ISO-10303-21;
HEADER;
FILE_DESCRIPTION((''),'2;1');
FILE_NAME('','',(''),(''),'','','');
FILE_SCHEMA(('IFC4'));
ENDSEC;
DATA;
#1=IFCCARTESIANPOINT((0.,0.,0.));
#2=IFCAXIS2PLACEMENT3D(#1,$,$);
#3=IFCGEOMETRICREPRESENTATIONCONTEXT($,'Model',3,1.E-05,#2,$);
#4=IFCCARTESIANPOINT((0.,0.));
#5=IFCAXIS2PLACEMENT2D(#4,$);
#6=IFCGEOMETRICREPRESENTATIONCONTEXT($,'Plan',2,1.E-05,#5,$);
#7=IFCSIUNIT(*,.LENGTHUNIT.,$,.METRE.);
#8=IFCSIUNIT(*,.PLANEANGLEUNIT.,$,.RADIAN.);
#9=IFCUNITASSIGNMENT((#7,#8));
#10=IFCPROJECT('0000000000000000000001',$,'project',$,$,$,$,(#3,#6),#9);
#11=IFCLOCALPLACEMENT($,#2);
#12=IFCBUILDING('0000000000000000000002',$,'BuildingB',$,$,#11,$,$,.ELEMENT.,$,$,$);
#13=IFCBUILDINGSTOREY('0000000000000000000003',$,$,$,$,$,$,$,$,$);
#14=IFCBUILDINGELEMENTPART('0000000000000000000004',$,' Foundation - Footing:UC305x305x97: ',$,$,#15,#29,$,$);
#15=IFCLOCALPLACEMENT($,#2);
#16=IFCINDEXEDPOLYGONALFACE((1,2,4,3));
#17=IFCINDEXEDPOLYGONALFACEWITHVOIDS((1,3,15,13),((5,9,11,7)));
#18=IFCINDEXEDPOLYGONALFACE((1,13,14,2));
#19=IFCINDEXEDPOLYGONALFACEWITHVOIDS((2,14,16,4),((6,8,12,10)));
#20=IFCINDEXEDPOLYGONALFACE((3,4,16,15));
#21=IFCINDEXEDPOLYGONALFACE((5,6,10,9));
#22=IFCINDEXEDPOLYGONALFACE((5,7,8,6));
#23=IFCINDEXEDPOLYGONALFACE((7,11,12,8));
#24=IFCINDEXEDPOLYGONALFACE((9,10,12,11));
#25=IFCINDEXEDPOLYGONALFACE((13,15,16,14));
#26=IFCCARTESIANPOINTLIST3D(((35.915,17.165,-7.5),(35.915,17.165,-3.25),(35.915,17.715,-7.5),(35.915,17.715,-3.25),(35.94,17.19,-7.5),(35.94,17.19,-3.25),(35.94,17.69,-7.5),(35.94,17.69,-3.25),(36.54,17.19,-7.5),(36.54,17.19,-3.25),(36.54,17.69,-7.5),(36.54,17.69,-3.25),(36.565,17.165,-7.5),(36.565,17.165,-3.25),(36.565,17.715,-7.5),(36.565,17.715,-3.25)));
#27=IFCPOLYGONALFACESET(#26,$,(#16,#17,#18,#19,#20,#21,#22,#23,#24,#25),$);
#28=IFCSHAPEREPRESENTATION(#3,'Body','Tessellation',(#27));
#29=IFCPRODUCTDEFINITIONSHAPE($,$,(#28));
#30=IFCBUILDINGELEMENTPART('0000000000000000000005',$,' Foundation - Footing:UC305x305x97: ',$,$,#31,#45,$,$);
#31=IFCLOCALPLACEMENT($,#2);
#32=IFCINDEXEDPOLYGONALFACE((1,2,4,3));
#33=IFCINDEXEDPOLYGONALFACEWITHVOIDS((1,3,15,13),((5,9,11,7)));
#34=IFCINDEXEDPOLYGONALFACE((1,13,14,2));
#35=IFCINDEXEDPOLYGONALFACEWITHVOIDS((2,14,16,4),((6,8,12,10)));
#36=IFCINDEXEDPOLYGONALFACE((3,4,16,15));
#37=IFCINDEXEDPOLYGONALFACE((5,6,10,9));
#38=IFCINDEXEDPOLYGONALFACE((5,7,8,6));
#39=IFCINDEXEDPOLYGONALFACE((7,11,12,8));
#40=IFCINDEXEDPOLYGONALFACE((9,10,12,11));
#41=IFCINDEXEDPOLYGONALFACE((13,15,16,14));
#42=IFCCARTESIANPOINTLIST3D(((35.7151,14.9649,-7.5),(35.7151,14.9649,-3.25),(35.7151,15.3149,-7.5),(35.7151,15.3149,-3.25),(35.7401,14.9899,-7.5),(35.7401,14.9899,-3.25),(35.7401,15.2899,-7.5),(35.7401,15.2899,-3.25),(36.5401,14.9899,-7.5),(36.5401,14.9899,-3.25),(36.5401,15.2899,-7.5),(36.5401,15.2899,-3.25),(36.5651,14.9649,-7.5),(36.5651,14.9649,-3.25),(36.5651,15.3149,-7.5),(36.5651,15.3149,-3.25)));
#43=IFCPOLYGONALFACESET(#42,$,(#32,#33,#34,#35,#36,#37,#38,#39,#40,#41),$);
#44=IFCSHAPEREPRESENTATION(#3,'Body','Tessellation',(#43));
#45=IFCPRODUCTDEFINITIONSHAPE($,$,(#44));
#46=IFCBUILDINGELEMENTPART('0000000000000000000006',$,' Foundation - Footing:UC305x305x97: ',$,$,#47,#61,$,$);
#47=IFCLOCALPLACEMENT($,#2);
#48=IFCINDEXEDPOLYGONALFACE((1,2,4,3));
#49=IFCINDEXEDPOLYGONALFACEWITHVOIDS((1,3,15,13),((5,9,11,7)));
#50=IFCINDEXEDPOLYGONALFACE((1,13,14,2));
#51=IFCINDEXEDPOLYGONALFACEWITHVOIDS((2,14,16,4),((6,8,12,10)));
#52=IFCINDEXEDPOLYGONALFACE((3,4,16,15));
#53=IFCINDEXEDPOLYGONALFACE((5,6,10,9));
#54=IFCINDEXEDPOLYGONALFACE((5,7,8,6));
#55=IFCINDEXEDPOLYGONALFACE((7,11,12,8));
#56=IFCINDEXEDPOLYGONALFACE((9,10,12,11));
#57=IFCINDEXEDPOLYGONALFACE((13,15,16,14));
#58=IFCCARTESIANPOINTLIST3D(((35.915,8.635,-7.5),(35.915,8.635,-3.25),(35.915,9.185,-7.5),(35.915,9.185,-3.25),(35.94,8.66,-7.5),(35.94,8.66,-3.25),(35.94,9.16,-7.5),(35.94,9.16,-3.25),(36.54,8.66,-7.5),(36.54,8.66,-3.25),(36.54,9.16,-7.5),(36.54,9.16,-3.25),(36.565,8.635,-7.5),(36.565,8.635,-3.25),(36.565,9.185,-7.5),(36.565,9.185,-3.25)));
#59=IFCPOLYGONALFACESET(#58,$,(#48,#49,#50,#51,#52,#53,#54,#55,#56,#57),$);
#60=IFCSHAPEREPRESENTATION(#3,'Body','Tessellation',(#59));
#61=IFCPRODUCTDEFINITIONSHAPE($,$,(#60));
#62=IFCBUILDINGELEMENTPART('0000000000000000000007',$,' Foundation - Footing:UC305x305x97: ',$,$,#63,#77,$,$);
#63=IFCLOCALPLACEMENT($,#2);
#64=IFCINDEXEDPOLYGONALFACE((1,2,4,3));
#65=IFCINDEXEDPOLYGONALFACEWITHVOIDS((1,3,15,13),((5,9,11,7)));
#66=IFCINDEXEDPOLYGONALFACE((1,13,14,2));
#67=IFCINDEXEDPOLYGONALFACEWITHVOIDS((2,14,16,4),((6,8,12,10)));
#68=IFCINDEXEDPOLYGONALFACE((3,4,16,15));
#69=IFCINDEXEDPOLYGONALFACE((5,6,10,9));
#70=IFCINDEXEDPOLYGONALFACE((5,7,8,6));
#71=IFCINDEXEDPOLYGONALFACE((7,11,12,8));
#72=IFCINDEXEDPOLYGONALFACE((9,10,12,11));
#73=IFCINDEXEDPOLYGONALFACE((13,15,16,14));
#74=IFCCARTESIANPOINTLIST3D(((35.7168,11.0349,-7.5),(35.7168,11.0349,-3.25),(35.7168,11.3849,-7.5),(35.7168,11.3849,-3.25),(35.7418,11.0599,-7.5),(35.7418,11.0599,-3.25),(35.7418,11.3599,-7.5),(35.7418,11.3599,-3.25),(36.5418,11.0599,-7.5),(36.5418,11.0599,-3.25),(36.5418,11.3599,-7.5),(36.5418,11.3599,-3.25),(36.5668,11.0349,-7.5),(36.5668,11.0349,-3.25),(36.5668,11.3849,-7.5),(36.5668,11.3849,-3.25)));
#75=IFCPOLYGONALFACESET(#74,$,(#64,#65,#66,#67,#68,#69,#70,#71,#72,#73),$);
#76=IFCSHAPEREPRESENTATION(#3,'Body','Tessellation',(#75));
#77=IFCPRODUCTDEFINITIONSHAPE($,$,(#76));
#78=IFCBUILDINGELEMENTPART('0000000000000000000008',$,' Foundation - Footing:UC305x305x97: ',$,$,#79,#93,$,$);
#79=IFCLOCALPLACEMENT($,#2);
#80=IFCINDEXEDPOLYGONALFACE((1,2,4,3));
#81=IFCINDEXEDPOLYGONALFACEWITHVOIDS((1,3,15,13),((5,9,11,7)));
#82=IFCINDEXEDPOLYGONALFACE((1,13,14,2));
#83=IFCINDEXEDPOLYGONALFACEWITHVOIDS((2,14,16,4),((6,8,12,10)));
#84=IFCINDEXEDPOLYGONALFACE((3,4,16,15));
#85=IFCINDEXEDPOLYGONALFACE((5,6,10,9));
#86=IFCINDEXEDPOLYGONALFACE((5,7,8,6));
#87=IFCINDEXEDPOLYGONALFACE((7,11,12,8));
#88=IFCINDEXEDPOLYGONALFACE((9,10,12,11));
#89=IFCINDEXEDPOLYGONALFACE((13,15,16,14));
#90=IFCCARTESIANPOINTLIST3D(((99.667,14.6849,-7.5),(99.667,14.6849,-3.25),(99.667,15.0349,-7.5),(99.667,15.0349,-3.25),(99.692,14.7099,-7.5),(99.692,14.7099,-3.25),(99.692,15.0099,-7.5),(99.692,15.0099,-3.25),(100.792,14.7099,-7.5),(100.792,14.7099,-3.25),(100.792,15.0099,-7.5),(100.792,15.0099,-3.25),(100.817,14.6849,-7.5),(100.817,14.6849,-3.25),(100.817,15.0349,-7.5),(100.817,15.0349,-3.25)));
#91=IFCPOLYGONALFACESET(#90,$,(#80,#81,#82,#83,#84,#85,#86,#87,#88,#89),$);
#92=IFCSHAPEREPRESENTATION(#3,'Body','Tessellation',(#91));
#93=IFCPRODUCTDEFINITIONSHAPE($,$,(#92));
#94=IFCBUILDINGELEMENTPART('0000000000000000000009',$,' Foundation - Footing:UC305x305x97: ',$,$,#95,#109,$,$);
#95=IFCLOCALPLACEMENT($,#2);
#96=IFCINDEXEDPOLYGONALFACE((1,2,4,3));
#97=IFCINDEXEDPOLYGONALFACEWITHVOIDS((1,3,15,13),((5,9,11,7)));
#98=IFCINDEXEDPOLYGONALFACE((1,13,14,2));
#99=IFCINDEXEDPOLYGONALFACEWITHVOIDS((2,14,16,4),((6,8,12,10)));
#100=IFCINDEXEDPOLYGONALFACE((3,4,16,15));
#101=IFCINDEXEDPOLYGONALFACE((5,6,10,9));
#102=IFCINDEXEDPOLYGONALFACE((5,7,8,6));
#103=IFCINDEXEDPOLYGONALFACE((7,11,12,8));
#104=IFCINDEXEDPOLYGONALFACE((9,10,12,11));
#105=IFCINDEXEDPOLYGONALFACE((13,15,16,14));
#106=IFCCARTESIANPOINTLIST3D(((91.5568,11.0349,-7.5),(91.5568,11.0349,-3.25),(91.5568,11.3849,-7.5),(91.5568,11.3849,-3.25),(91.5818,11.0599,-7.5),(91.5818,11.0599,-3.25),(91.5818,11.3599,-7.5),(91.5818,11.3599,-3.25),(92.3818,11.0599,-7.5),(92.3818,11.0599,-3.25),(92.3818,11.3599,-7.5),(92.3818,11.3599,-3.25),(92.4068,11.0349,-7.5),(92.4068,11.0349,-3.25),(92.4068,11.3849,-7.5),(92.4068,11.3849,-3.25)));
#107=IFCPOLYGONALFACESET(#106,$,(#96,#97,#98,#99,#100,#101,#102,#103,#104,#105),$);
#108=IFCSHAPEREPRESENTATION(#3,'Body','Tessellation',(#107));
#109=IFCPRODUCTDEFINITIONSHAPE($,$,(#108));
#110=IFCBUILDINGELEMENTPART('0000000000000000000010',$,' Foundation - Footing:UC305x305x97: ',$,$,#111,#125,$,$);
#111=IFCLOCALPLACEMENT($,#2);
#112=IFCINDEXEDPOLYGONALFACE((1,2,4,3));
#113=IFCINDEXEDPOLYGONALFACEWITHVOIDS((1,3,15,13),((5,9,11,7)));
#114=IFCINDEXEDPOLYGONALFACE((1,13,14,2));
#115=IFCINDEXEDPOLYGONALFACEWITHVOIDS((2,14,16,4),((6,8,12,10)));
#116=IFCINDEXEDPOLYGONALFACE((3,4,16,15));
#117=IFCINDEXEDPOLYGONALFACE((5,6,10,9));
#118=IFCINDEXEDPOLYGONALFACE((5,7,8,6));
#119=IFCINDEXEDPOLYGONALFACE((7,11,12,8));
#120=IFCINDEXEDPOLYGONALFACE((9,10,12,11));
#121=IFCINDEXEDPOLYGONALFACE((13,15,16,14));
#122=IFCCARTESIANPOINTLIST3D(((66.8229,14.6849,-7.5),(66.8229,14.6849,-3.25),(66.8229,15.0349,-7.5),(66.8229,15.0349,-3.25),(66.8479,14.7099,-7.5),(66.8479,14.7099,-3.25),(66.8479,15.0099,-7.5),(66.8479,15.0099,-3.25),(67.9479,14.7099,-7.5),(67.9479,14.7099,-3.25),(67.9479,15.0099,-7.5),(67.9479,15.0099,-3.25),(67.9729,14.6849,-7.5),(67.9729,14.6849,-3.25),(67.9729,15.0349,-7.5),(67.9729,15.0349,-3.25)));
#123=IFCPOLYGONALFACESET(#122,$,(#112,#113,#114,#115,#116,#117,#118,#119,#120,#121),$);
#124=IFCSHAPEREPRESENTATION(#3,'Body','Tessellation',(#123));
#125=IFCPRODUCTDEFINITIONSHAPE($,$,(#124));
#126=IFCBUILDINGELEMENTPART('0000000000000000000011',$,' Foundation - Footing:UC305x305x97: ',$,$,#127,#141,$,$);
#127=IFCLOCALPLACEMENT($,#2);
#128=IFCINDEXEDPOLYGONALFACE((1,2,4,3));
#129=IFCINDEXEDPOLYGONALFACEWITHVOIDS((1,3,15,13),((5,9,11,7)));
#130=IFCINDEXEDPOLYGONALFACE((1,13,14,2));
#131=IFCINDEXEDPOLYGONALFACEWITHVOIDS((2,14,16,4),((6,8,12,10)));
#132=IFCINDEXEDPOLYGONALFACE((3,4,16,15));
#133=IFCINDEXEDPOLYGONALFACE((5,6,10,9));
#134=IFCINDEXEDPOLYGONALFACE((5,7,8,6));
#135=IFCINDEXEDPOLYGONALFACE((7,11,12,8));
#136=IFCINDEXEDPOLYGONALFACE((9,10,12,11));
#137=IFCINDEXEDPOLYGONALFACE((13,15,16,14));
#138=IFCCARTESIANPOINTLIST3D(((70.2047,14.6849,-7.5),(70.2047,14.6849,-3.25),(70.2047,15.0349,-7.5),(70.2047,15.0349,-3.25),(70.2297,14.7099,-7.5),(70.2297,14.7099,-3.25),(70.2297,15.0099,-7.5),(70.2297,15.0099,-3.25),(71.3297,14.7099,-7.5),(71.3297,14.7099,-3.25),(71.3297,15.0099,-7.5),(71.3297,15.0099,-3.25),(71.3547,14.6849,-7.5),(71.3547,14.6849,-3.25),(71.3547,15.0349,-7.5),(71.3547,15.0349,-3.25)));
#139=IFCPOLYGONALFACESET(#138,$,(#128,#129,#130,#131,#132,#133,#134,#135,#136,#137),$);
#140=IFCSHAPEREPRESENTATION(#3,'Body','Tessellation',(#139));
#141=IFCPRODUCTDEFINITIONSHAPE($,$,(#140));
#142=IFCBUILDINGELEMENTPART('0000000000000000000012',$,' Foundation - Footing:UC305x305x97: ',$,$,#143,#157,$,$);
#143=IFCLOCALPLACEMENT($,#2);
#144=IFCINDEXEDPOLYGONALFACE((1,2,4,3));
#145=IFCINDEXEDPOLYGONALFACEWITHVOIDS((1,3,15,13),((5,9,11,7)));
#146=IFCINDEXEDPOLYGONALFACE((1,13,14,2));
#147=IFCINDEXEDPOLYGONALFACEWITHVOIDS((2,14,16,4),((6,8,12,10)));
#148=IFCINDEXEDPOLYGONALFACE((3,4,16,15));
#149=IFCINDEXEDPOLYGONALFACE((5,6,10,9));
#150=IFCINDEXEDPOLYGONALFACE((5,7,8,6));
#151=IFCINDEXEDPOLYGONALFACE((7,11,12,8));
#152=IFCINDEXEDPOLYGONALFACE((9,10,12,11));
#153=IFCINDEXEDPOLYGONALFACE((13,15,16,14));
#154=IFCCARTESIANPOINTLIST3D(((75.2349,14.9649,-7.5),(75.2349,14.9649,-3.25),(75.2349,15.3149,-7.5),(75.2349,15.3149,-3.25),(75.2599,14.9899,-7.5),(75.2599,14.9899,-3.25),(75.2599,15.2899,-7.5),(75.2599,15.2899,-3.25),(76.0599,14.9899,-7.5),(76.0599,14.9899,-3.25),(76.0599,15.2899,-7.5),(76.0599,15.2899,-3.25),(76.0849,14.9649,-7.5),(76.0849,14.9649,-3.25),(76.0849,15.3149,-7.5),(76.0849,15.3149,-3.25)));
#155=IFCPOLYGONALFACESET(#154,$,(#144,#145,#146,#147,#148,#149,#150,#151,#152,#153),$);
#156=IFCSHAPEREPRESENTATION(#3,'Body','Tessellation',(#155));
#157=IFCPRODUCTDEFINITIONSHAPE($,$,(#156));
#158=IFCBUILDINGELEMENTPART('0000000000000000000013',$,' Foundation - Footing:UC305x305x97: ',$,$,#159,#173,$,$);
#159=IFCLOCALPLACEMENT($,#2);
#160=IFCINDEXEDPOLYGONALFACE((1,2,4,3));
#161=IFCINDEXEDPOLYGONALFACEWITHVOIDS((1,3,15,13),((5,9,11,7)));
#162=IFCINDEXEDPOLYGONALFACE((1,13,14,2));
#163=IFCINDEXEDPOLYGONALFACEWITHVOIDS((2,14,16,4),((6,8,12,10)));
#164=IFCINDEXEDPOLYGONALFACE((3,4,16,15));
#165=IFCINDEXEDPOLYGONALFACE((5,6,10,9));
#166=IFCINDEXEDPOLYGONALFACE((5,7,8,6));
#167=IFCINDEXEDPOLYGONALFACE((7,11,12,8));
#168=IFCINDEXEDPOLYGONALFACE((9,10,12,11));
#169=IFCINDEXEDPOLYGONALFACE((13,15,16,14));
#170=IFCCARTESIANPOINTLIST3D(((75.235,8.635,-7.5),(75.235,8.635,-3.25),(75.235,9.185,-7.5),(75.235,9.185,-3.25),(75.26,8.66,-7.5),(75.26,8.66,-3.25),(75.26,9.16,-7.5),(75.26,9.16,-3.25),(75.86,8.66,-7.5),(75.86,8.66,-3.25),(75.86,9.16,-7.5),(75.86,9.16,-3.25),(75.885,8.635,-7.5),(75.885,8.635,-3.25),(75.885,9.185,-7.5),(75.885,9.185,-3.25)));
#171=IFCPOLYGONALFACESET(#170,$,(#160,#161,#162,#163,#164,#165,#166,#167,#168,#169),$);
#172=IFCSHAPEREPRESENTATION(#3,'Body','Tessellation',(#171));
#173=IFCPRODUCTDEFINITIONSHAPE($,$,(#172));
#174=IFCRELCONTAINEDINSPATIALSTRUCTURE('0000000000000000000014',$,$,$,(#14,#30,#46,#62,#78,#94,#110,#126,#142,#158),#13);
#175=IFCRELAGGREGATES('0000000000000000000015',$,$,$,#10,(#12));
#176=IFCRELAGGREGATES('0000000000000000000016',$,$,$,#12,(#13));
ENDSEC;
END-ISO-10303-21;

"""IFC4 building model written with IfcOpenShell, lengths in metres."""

from ifc_helpers import new_model, si_unit, origin, origin_2d, place, context, project, spatial, polyline, outline, extrude, element, save


model = new_model("IFC4")

# Units and contexts
model_context = context("Model", 3, precision=1e-05, world=origin())
plan_context = context("Plan", 2, precision=1e-05, world=origin_2d())
ifc_project = project(units=[si_unit("LENGTHUNIT", "METRE"), si_unit("PLANEANGLEUNIT", "RADIAN")], contexts=[model_context, plan_context])

# Building, storey
building_placement = place(None, origin())
building = spatial("IfcBuilding", under=ifc_project, at=building_placement, Name="BuildingB", CompositionType="ELEMENT")
storey = spatial("IfcBuildingStorey", under=building)

# Building element parts, openings
building_element_part_1 = element("IfcBuildingElementPart", 1, inside=storey, Name=" Foundation - Footing:UC305x305x97: ", context=model_context, shape_type="SweptSolid", body=[
    extrude(outline(polyline([(36.565, 17.715, -7.5), (35.915, 17.715, -7.5), (35.915, 17.165, -7.5), (36.565, 17.165, -7.5), (36.565, 17.715, -7.5)])), None, (0.0, 0.0, 1.0), 4.25),
])
element("IfcOpeningElement", 2, inside=storey, cuts=building_element_part_1, context=model_context, shape_type="SweptSolid", body=[
    extrude(outline(polyline([(36.54, 17.69, -7.5), (35.94, 17.69, -7.5), (35.94, 17.19, -7.5), (36.54, 17.19, -7.5), (36.54, 17.69, -7.5)])), None, (0.0, 0.0, 1.0), 4.25),
])
building_element_part_2 = element("IfcBuildingElementPart", 3, inside=storey, Name=" Foundation - Footing:UC305x305x97: ", context=model_context, shape_type="SweptSolid", body=[
    extrude(outline(polyline([(36.5651, 15.3149, -7.5), (35.7151, 15.3149, -7.5), (35.7151, 14.9649, -7.5), (36.5651, 14.9649, -7.5), (36.5651, 15.3149, -7.5)])), None, (0.0, 0.0, 1.0), 4.25),
])
element("IfcOpeningElement", 4, inside=storey, cuts=building_element_part_2, context=model_context, shape_type="SweptSolid", body=[
    extrude(outline(polyline([(36.5401, 15.2899, -7.5), (35.7401, 15.2899, -7.5), (35.7401, 14.9899, -7.5), (36.5401, 14.9899, -7.5), (36.5401, 15.2899, -7.5)])), None, (0.0, 0.0, 1.0), 4.25),
])
building_element_part_3 = element("IfcBuildingElementPart", 5, inside=storey, Name=" Foundation - Footing:UC305x305x97: ", context=model_context, shape_type="SweptSolid", body=[
    extrude(outline(polyline([(36.565, 8.635, -7.5), (35.915, 8.635, -7.5), (35.915, 9.185, -7.5), (36.565, 9.185, -7.5), (36.565, 8.635, -7.5)])), None, (0.0, 0.0, 1.0), 4.25),
])
element("IfcOpeningElement", 6, inside=storey, cuts=building_element_part_3, context=model_context, shape_type="SweptSolid", body=[
    extrude(outline(polyline([(36.54, 8.66, -7.5), (35.94, 8.66, -7.5), (35.94, 9.16, -7.5), (36.54, 9.16, -7.5), (36.54, 8.66, -7.5)])), None, (0.0, 0.0, 1.0), 4.25),
])
building_element_part_4 = element("IfcBuildingElementPart", 7, inside=storey, Name=" Foundation - Footing:UC305x305x97: ", context=model_context, shape_type="SweptSolid", body=[
    extrude(outline(polyline([(36.5668, 11.0349, -7.5), (35.7168, 11.0349, -7.5), (35.7168, 11.3849, -7.5), (36.5668, 11.3849, -7.5), (36.5668, 11.0349, -7.5)])), None, (0.0, 0.0, 1.0), 4.25),
])
element("IfcOpeningElement", 8, inside=storey, cuts=building_element_part_4, context=model_context, shape_type="SweptSolid", body=[
    extrude(outline(polyline([(36.5418, 11.0599, -7.5), (35.7418, 11.0599, -7.5), (35.7418, 11.3599, -7.5), (36.5418, 11.3599, -7.5), (36.5418, 11.0599, -7.5)])), None, (0.0, 0.0, 1.0), 4.25),
])
building_element_part_5 = element("IfcBuildingElementPart", 9, inside=storey, Name=" Foundation - Footing:UC305x305x97: ", context=model_context, shape_type="SweptSolid", body=[
    extrude(outline(polyline([(100.817, 14.6849, -7.5), (100.817, 15.0349, -7.5), (99.667, 15.0349, -7.5), (99.667, 14.6849, -7.5), (100.817, 14.6849, -7.5)])), None, (0.0, 0.0, 1.0), 4.25),
])
element("IfcOpeningElement", 10, inside=storey, cuts=building_element_part_5, context=model_context, shape_type="SweptSolid", body=[
    extrude(outline(polyline([(100.792, 14.7099, -7.5), (100.792, 15.0099, -7.5), (99.692, 15.0099, -7.5), (99.692, 14.7099, -7.5), (100.792, 14.7099, -7.5)])), None, (0.0, 0.0, 1.0), 4.25),
])
building_element_part_6 = element("IfcBuildingElementPart", 11, inside=storey, Name=" Foundation - Footing:UC305x305x97: ", context=model_context, shape_type="SweptSolid", body=[
    extrude(outline(polyline([(92.4068, 11.0349, -7.5), (91.5568, 11.0349, -7.5), (91.5568, 11.3849, -7.5), (92.4068, 11.3849, -7.5), (92.4068, 11.0349, -7.5)])), None, (0.0, 0.0, 1.0), 4.25),
])
element("IfcOpeningElement", 12, inside=storey, cuts=building_element_part_6, context=model_context, shape_type="SweptSolid", body=[
    extrude(outline(polyline([(92.3818, 11.0599, -7.5), (91.5818, 11.0599, -7.5), (91.5818, 11.3599, -7.5), (92.3818, 11.3599, -7.5), (92.3818, 11.0599, -7.5)])), None, (0.0, 0.0, 1.0), 4.25),
])
building_element_part_7 = element("IfcBuildingElementPart", 13, inside=storey, Name=" Foundation - Footing:UC305x305x97: ", context=model_context, shape_type="SweptSolid", body=[
    extrude(outline(polyline([(66.8229, 14.6849, -7.5), (66.8229, 15.0349, -7.5), (67.9729, 15.0349, -7.5), (67.9729, 14.6849, -7.5), (66.8229, 14.6849, -7.5)])), None, (0.0, 0.0, 1.0), 4.25),
])
element("IfcOpeningElement", 14, inside=storey, cuts=building_element_part_7, context=model_context, shape_type="SweptSolid", body=[
    extrude(outline(polyline([(66.8479, 14.7099, -7.5), (66.8479, 15.0099, -7.5), (67.9479, 15.0099, -7.5), (67.9479, 14.7099, -7.5), (66.8479, 14.7099, -7.5)])), None, (0.0, 0.0, 1.0), 4.25),
])
building_element_part_8 = element("IfcBuildingElementPart", 15, inside=storey, Name=" Foundation - Footing:UC305x305x97: ", context=model_context, shape_type="SweptSolid", body=[
    extrude(outline(polyline([(70.2047, 15.0349, -7.5), (71.3547, 15.0349, -7.5), (71.3547, 14.6849, -7.5), (70.2047, 14.6849, -7.5), (70.2047, 15.0349, -7.5)])), None, (0.0, 0.0, 1.0), 4.25),
])
element("IfcOpeningElement", 16, inside=storey, cuts=building_element_part_8, context=model_context, shape_type="SweptSolid", body=[
    extrude(outline(polyline([(70.2297, 15.0099, -7.5), (71.3297, 15.0099, -7.5), (71.3297, 14.7099, -7.5), (70.2297, 14.7099, -7.5), (70.2297, 15.0099, -7.5)])), None, (0.0, 0.0, 1.0), 4.25),
])
building_element_part_9 = element("IfcBuildingElementPart", 17, inside=storey, Name=" Foundation - Footing:UC305x305x97: ", context=model_context, shape_type="SweptSolid", body=[
    extrude(outline(polyline([(75.2349, 15.3149, -7.5), (76.0849, 15.3149, -7.5), (76.0849, 14.9649, -7.5), (75.2349, 14.9649, -7.5), (75.2349, 15.3149, -7.5)])), None, (0.0, 0.0, 1.0), 4.25),
])
element("IfcOpeningElement", 18, inside=storey, cuts=building_element_part_9, context=model_context, shape_type="SweptSolid", body=[
    extrude(outline(polyline([(75.2599, 15.2899, -7.5), (76.0599, 15.2899, -7.5), (76.0599, 14.9899, -7.5), (75.2599, 14.9899, -7.5), (75.2599, 15.2899, -7.5)])), None, (0.0, 0.0, 1.0), 4.25),
])
building_element_part_10 = element("IfcBuildingElementPart", 19, inside=storey, Name=" Foundation - Footing:UC305x305x97: ", context=model_context, shape_type="SweptSolid", body=[
    extrude(outline(polyline([(75.235, 8.635, -7.5), (75.885, 8.635, -7.5), (75.885, 9.185, -7.5), (75.235, 9.185, -7.5), (75.235, 8.635, -7.5)])), None, (0.0, 0.0, 1.0), 4.25),
])
element("IfcOpeningElement", 20, inside=storey, cuts=building_element_part_10, context=model_context, shape_type="SweptSolid", body=[
    extrude(outline(polyline([(75.26, 8.66, -7.5), (75.86, 8.66, -7.5), (75.86, 9.16, -7.5), (75.26, 9.16, -7.5), (75.26, 8.66, -7.5)])), None, (0.0, 0.0, 1.0), 4.25),
])

save(model, "model.ifc")
